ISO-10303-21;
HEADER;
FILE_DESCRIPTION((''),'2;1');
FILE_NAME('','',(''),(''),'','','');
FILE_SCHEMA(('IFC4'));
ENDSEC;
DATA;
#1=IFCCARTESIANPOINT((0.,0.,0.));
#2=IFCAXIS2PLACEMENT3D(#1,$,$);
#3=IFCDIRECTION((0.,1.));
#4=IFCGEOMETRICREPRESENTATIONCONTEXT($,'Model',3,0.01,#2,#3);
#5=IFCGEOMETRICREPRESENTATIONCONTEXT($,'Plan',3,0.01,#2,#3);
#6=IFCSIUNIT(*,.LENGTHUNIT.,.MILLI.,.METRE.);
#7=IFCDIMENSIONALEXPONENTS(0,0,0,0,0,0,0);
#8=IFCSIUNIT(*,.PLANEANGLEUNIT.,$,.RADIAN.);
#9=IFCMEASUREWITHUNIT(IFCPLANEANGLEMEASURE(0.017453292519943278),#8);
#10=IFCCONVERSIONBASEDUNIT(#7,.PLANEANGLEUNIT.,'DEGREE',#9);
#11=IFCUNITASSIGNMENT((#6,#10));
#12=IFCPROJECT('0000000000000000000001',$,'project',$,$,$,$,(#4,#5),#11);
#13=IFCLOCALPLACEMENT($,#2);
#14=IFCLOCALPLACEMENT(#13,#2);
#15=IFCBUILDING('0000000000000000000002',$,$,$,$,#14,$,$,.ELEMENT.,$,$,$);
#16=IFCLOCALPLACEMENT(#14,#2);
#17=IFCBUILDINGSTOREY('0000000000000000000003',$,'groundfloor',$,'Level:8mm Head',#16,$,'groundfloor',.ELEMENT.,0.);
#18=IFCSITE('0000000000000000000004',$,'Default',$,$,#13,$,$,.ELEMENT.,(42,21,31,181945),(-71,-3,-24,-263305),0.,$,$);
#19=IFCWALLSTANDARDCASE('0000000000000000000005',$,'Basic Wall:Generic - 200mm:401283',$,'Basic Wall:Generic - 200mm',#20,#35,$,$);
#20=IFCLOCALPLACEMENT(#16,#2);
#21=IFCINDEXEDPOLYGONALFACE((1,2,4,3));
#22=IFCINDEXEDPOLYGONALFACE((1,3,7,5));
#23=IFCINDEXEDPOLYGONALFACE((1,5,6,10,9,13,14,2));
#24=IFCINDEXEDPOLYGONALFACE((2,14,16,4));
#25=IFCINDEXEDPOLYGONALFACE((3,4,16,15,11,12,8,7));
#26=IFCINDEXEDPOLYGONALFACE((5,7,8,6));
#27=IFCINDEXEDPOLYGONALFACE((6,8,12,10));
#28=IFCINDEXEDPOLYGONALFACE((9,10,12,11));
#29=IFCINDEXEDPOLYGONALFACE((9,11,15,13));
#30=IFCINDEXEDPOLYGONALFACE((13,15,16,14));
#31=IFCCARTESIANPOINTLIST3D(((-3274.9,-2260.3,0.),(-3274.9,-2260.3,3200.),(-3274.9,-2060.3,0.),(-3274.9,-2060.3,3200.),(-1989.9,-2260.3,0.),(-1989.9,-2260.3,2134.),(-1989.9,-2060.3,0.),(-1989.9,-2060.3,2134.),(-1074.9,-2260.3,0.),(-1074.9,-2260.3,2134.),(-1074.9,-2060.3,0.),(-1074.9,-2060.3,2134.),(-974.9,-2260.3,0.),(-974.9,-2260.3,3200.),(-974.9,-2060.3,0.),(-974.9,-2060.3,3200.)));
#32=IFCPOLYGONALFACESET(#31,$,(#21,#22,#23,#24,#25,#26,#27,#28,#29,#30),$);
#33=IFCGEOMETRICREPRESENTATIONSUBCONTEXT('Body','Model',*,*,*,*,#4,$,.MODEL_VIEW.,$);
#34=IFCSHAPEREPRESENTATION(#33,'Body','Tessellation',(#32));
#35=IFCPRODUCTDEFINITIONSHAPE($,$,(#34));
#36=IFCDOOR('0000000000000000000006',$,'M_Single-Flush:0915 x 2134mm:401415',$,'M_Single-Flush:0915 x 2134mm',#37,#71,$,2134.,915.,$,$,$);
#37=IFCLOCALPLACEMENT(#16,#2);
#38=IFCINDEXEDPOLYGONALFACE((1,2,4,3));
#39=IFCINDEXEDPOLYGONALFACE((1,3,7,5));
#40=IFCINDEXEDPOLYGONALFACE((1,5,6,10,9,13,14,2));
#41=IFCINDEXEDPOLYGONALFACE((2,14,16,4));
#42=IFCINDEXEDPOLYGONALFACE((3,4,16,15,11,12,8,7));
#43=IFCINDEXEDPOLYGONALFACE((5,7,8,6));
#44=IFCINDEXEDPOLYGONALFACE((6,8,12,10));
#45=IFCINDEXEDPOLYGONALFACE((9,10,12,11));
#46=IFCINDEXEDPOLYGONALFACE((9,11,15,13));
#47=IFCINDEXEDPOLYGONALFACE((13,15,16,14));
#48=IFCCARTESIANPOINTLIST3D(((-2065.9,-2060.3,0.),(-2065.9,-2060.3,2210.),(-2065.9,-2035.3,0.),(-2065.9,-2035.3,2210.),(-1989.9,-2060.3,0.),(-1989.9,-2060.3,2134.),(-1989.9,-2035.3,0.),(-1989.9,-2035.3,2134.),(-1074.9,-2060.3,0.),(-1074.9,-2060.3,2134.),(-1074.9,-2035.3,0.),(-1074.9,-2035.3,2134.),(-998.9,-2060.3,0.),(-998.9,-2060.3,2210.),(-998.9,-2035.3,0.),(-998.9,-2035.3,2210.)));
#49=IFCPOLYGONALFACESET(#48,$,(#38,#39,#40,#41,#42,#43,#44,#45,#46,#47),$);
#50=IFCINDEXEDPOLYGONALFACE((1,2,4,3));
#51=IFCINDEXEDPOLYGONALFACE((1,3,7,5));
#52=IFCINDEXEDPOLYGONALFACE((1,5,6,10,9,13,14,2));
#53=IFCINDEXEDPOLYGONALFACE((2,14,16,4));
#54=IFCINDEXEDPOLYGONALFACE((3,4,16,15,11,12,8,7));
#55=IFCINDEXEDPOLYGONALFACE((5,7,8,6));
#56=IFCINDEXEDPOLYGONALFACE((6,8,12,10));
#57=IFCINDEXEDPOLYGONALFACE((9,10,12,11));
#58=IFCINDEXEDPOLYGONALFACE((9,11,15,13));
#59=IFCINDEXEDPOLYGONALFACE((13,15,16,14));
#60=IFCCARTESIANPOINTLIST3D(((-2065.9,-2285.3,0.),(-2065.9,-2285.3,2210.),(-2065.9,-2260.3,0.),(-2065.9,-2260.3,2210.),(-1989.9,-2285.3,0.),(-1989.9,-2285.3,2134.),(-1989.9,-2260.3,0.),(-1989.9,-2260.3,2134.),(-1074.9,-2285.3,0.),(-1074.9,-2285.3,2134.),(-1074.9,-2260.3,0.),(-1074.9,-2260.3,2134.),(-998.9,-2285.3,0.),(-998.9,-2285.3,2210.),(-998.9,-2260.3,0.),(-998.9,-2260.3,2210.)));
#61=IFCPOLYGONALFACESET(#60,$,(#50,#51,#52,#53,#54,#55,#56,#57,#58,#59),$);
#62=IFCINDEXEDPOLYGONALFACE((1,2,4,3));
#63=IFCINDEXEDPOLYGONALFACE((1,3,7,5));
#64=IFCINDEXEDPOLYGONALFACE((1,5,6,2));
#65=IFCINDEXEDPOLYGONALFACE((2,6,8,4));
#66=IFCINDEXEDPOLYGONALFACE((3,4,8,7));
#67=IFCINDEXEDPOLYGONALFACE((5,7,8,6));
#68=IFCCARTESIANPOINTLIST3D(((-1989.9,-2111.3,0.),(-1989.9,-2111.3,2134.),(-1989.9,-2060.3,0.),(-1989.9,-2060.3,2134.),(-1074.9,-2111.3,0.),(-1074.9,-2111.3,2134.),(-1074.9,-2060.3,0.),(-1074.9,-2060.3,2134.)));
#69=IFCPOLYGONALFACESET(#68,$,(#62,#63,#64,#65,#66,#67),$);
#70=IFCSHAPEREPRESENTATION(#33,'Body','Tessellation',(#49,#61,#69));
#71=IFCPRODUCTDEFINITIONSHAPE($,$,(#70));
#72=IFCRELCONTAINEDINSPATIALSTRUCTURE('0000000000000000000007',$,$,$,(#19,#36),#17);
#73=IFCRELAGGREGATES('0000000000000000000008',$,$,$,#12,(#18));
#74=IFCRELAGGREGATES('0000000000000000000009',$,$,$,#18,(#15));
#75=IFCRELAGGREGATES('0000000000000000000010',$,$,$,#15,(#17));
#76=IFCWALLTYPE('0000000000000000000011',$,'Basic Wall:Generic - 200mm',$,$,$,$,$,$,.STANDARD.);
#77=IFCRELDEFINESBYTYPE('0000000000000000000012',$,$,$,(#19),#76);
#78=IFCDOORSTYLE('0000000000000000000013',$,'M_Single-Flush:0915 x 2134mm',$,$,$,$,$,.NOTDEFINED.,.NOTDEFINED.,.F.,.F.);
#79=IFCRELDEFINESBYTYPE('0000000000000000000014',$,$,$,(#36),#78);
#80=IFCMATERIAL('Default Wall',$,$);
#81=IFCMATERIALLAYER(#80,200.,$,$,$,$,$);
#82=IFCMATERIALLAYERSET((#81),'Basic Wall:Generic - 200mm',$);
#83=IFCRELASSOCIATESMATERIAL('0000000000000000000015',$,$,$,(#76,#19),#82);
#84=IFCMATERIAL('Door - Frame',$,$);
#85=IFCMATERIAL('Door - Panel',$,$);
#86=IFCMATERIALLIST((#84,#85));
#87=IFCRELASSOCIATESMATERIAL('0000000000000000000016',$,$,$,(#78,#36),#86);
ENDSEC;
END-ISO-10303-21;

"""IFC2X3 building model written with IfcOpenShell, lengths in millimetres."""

from ifc_helpers import new_model, entity, si_unit, converted_unit, direction, frame, frame_2d, origin, place, context, subcontext, project, spatial, polyline, rectangle, outline, extrude, source, transform, mapped, material, material_list, layer, layer_set, layer_usage, type_object, type_shapes, element, fill, save


model = new_model("IFC2X3")

# Units and contexts
model_context = context("Model", 3, precision=0.01, world=origin(), true_north=direction((0.0, 1.0)))
plan_context = context("Plan", 3, precision=0.01, world=origin(), true_north=direction((0.0, 1.0)))
body_context = subcontext(model_context, "Body", "Model", "MODEL_VIEW")
ifc_project = project(units=[si_unit("LENGTHUNIT", "METRE", prefix="MILLI"), converted_unit("PLANEANGLEUNIT", "DEGREE", entity("IfcPlaneAngleMeasure", 0.017453292519943278), si_unit("PLANEANGLEUNIT", "RADIAN"), dimensions=[0, 0, 0, 0, 0, 0, 0])], contexts=[model_context, plan_context])

# Site, building, storey
site_placement = place(None, origin())
site = spatial("IfcSite", under=ifc_project, at=site_placement, Name="Default", CompositionType="ELEMENT", RefLatitude=(42, 21, 31, 181945), RefLongitude=(-71, -3, -24, -263305), RefElevation=0.0)
building_placement = place(site_placement, origin())
building = spatial("IfcBuilding", under=site, at=building_placement, CompositionType="ELEMENT")
storey_placement = place(building_placement, origin())
storey = spatial("IfcBuildingStorey", under=building, at=storey_placement, Name="groundfloor", ObjectType="Level:8mm Head", LongName="groundfloor", CompositionType="ELEMENT", Elevation=0.0)

# Shared definitions
ifc_material_1 = material(Name="Default Wall")

# Shared definitions
ifc_layer_1 = layer(ifc_material_1, 200.0)
ifc_layer_set_1 = layer_set([ifc_layer_1], Name="Basic Wall:Generic - 200mm")
ifc_layer_usage_1 = layer_usage(ifc_layer_set_1, "AXIS2", "NEGATIVE", 100.0)
wall_type_1 = type_object("IfcWallType", Name="Basic Wall:Generic - 200mm", PredefinedType="STANDARD", material=ifc_layer_set_1)

# Shared definitions
ifc_material_2 = material(Name="Door - Frame")
ifc_material_3 = material(Name="Door - Panel")
ifc_material_list_1 = material_list([ifc_material_2, ifc_material_3])
door_style_1 = type_object("IfcDoorStyle", Name="M_Single-Flush:0915 x 2134mm", ConstructionType="NOTDEFINED", OperationType="NOTDEFINED", ParameterTakesPrecedence=False, Sizeable=False, material=ifc_material_list_1)
shared_shape_1 = source(origin(), body_context, "Body", "SweptSolid", [
    extrude(outline(polyline([(-533.5, -1124.0), (533.5, -1124.0), (533.5, 1086.0), (457.5, 1086.0), (457.5, -1048.0), (-457.5, -1048.0), (-457.5, 1086.0), (-533.5, 1086.0), (-533.5, -1124.0)])), frame((457.5, 200.0, 1086.0), z_axis=(0.0, 1.0, 0.0), x_axis=(1.0, 0.0, 0.0)), (0.0, 0.0, 1.0), 25.0),
    extrude(outline(polyline([(-1124.0, -533.5), (1086.0, -533.5), (1086.0, -457.5), (-1048.0, -457.5), (-1048.0, 457.5), (1086.0, 457.5), (1086.0, 533.5), (-1124.0, 533.5), (-1124.0, -533.5)])), frame((457.5, -25.0, 1086.0), z_axis=(0.0, 1.0, 0.0), x_axis=(0.0, 0.0, -1.0)), (0.0, 0.0, 1.0), 25.0),
    extrude(rectangle(XDim=51.0, YDim=915.0, at=frame_2d((0.0, 0.0), x_axis=(1.0, 0.0))), frame((457.5, 174.5, 0.0), z_axis=(0.0, 0.0, 1.0), x_axis=(0.0, 1.0, 0.0)), (0.0, 0.0, 1.0), 2134.0),
])
type_shapes(door_style_1, [shared_shape_1])

# Wall, opening, door
wall_1_placement = place(storey_placement, frame((-3274.9, -2160.3, 0.0)))
wall_1 = element("IfcWallStandardCase", 1, at=wall_1_placement, inside=storey, type_object=wall_type_1, material=ifc_layer_usage_1, Name="Basic Wall:Generic - 200mm:401283", ObjectType="Basic Wall:Generic - 200mm", context=body_context, shape_type="SweptSolid", body=[
    extrude(rectangle(XDim=2300.0, YDim=200.0, at=frame_2d((1150.0, 0.0), x_axis=(-1.0, 0.0))), origin(), (0.0, 0.0, 1.0), 3200.0),
])
opening_1_placement = place(wall_1_placement, frame((1285.0, -100.0, 0.0)))
opening_1 = element("IfcOpeningElement", 2, at=opening_1_placement, cuts=wall_1, ObjectType="Opening", context=body_context, shape_type="SweptSolid", body=[
    extrude(rectangle(XDim=915.0, YDim=2134.0, at=frame_2d((1067.0, 457.5), x_axis=(0.0, 1.0))), frame((0.0, 0.0, 0.0), z_axis=(0.0, 1.0, 0.0), x_axis=(0.0, 0.0, 1.0)), (0.0, 0.0, 1.0), 200.0),
])
door_1_placement = place(opening_1_placement, origin())
door_1 = element("IfcDoor", 3, at=door_1_placement, inside=storey, type_object=door_style_1, material=ifc_material_list_1, Name="M_Single-Flush:0915 x 2134mm:401415", ObjectType="M_Single-Flush:0915 x 2134mm", OverallHeight=2134.0, OverallWidth=915.0, context=body_context, shape_type="MappedRepresentation", body=[
    mapped(shared_shape_1, transform((0.0, 0.0, 0.0), scale=1.0)),
])
fill(opening_1, door_1)

save(model, "model.ifc")
